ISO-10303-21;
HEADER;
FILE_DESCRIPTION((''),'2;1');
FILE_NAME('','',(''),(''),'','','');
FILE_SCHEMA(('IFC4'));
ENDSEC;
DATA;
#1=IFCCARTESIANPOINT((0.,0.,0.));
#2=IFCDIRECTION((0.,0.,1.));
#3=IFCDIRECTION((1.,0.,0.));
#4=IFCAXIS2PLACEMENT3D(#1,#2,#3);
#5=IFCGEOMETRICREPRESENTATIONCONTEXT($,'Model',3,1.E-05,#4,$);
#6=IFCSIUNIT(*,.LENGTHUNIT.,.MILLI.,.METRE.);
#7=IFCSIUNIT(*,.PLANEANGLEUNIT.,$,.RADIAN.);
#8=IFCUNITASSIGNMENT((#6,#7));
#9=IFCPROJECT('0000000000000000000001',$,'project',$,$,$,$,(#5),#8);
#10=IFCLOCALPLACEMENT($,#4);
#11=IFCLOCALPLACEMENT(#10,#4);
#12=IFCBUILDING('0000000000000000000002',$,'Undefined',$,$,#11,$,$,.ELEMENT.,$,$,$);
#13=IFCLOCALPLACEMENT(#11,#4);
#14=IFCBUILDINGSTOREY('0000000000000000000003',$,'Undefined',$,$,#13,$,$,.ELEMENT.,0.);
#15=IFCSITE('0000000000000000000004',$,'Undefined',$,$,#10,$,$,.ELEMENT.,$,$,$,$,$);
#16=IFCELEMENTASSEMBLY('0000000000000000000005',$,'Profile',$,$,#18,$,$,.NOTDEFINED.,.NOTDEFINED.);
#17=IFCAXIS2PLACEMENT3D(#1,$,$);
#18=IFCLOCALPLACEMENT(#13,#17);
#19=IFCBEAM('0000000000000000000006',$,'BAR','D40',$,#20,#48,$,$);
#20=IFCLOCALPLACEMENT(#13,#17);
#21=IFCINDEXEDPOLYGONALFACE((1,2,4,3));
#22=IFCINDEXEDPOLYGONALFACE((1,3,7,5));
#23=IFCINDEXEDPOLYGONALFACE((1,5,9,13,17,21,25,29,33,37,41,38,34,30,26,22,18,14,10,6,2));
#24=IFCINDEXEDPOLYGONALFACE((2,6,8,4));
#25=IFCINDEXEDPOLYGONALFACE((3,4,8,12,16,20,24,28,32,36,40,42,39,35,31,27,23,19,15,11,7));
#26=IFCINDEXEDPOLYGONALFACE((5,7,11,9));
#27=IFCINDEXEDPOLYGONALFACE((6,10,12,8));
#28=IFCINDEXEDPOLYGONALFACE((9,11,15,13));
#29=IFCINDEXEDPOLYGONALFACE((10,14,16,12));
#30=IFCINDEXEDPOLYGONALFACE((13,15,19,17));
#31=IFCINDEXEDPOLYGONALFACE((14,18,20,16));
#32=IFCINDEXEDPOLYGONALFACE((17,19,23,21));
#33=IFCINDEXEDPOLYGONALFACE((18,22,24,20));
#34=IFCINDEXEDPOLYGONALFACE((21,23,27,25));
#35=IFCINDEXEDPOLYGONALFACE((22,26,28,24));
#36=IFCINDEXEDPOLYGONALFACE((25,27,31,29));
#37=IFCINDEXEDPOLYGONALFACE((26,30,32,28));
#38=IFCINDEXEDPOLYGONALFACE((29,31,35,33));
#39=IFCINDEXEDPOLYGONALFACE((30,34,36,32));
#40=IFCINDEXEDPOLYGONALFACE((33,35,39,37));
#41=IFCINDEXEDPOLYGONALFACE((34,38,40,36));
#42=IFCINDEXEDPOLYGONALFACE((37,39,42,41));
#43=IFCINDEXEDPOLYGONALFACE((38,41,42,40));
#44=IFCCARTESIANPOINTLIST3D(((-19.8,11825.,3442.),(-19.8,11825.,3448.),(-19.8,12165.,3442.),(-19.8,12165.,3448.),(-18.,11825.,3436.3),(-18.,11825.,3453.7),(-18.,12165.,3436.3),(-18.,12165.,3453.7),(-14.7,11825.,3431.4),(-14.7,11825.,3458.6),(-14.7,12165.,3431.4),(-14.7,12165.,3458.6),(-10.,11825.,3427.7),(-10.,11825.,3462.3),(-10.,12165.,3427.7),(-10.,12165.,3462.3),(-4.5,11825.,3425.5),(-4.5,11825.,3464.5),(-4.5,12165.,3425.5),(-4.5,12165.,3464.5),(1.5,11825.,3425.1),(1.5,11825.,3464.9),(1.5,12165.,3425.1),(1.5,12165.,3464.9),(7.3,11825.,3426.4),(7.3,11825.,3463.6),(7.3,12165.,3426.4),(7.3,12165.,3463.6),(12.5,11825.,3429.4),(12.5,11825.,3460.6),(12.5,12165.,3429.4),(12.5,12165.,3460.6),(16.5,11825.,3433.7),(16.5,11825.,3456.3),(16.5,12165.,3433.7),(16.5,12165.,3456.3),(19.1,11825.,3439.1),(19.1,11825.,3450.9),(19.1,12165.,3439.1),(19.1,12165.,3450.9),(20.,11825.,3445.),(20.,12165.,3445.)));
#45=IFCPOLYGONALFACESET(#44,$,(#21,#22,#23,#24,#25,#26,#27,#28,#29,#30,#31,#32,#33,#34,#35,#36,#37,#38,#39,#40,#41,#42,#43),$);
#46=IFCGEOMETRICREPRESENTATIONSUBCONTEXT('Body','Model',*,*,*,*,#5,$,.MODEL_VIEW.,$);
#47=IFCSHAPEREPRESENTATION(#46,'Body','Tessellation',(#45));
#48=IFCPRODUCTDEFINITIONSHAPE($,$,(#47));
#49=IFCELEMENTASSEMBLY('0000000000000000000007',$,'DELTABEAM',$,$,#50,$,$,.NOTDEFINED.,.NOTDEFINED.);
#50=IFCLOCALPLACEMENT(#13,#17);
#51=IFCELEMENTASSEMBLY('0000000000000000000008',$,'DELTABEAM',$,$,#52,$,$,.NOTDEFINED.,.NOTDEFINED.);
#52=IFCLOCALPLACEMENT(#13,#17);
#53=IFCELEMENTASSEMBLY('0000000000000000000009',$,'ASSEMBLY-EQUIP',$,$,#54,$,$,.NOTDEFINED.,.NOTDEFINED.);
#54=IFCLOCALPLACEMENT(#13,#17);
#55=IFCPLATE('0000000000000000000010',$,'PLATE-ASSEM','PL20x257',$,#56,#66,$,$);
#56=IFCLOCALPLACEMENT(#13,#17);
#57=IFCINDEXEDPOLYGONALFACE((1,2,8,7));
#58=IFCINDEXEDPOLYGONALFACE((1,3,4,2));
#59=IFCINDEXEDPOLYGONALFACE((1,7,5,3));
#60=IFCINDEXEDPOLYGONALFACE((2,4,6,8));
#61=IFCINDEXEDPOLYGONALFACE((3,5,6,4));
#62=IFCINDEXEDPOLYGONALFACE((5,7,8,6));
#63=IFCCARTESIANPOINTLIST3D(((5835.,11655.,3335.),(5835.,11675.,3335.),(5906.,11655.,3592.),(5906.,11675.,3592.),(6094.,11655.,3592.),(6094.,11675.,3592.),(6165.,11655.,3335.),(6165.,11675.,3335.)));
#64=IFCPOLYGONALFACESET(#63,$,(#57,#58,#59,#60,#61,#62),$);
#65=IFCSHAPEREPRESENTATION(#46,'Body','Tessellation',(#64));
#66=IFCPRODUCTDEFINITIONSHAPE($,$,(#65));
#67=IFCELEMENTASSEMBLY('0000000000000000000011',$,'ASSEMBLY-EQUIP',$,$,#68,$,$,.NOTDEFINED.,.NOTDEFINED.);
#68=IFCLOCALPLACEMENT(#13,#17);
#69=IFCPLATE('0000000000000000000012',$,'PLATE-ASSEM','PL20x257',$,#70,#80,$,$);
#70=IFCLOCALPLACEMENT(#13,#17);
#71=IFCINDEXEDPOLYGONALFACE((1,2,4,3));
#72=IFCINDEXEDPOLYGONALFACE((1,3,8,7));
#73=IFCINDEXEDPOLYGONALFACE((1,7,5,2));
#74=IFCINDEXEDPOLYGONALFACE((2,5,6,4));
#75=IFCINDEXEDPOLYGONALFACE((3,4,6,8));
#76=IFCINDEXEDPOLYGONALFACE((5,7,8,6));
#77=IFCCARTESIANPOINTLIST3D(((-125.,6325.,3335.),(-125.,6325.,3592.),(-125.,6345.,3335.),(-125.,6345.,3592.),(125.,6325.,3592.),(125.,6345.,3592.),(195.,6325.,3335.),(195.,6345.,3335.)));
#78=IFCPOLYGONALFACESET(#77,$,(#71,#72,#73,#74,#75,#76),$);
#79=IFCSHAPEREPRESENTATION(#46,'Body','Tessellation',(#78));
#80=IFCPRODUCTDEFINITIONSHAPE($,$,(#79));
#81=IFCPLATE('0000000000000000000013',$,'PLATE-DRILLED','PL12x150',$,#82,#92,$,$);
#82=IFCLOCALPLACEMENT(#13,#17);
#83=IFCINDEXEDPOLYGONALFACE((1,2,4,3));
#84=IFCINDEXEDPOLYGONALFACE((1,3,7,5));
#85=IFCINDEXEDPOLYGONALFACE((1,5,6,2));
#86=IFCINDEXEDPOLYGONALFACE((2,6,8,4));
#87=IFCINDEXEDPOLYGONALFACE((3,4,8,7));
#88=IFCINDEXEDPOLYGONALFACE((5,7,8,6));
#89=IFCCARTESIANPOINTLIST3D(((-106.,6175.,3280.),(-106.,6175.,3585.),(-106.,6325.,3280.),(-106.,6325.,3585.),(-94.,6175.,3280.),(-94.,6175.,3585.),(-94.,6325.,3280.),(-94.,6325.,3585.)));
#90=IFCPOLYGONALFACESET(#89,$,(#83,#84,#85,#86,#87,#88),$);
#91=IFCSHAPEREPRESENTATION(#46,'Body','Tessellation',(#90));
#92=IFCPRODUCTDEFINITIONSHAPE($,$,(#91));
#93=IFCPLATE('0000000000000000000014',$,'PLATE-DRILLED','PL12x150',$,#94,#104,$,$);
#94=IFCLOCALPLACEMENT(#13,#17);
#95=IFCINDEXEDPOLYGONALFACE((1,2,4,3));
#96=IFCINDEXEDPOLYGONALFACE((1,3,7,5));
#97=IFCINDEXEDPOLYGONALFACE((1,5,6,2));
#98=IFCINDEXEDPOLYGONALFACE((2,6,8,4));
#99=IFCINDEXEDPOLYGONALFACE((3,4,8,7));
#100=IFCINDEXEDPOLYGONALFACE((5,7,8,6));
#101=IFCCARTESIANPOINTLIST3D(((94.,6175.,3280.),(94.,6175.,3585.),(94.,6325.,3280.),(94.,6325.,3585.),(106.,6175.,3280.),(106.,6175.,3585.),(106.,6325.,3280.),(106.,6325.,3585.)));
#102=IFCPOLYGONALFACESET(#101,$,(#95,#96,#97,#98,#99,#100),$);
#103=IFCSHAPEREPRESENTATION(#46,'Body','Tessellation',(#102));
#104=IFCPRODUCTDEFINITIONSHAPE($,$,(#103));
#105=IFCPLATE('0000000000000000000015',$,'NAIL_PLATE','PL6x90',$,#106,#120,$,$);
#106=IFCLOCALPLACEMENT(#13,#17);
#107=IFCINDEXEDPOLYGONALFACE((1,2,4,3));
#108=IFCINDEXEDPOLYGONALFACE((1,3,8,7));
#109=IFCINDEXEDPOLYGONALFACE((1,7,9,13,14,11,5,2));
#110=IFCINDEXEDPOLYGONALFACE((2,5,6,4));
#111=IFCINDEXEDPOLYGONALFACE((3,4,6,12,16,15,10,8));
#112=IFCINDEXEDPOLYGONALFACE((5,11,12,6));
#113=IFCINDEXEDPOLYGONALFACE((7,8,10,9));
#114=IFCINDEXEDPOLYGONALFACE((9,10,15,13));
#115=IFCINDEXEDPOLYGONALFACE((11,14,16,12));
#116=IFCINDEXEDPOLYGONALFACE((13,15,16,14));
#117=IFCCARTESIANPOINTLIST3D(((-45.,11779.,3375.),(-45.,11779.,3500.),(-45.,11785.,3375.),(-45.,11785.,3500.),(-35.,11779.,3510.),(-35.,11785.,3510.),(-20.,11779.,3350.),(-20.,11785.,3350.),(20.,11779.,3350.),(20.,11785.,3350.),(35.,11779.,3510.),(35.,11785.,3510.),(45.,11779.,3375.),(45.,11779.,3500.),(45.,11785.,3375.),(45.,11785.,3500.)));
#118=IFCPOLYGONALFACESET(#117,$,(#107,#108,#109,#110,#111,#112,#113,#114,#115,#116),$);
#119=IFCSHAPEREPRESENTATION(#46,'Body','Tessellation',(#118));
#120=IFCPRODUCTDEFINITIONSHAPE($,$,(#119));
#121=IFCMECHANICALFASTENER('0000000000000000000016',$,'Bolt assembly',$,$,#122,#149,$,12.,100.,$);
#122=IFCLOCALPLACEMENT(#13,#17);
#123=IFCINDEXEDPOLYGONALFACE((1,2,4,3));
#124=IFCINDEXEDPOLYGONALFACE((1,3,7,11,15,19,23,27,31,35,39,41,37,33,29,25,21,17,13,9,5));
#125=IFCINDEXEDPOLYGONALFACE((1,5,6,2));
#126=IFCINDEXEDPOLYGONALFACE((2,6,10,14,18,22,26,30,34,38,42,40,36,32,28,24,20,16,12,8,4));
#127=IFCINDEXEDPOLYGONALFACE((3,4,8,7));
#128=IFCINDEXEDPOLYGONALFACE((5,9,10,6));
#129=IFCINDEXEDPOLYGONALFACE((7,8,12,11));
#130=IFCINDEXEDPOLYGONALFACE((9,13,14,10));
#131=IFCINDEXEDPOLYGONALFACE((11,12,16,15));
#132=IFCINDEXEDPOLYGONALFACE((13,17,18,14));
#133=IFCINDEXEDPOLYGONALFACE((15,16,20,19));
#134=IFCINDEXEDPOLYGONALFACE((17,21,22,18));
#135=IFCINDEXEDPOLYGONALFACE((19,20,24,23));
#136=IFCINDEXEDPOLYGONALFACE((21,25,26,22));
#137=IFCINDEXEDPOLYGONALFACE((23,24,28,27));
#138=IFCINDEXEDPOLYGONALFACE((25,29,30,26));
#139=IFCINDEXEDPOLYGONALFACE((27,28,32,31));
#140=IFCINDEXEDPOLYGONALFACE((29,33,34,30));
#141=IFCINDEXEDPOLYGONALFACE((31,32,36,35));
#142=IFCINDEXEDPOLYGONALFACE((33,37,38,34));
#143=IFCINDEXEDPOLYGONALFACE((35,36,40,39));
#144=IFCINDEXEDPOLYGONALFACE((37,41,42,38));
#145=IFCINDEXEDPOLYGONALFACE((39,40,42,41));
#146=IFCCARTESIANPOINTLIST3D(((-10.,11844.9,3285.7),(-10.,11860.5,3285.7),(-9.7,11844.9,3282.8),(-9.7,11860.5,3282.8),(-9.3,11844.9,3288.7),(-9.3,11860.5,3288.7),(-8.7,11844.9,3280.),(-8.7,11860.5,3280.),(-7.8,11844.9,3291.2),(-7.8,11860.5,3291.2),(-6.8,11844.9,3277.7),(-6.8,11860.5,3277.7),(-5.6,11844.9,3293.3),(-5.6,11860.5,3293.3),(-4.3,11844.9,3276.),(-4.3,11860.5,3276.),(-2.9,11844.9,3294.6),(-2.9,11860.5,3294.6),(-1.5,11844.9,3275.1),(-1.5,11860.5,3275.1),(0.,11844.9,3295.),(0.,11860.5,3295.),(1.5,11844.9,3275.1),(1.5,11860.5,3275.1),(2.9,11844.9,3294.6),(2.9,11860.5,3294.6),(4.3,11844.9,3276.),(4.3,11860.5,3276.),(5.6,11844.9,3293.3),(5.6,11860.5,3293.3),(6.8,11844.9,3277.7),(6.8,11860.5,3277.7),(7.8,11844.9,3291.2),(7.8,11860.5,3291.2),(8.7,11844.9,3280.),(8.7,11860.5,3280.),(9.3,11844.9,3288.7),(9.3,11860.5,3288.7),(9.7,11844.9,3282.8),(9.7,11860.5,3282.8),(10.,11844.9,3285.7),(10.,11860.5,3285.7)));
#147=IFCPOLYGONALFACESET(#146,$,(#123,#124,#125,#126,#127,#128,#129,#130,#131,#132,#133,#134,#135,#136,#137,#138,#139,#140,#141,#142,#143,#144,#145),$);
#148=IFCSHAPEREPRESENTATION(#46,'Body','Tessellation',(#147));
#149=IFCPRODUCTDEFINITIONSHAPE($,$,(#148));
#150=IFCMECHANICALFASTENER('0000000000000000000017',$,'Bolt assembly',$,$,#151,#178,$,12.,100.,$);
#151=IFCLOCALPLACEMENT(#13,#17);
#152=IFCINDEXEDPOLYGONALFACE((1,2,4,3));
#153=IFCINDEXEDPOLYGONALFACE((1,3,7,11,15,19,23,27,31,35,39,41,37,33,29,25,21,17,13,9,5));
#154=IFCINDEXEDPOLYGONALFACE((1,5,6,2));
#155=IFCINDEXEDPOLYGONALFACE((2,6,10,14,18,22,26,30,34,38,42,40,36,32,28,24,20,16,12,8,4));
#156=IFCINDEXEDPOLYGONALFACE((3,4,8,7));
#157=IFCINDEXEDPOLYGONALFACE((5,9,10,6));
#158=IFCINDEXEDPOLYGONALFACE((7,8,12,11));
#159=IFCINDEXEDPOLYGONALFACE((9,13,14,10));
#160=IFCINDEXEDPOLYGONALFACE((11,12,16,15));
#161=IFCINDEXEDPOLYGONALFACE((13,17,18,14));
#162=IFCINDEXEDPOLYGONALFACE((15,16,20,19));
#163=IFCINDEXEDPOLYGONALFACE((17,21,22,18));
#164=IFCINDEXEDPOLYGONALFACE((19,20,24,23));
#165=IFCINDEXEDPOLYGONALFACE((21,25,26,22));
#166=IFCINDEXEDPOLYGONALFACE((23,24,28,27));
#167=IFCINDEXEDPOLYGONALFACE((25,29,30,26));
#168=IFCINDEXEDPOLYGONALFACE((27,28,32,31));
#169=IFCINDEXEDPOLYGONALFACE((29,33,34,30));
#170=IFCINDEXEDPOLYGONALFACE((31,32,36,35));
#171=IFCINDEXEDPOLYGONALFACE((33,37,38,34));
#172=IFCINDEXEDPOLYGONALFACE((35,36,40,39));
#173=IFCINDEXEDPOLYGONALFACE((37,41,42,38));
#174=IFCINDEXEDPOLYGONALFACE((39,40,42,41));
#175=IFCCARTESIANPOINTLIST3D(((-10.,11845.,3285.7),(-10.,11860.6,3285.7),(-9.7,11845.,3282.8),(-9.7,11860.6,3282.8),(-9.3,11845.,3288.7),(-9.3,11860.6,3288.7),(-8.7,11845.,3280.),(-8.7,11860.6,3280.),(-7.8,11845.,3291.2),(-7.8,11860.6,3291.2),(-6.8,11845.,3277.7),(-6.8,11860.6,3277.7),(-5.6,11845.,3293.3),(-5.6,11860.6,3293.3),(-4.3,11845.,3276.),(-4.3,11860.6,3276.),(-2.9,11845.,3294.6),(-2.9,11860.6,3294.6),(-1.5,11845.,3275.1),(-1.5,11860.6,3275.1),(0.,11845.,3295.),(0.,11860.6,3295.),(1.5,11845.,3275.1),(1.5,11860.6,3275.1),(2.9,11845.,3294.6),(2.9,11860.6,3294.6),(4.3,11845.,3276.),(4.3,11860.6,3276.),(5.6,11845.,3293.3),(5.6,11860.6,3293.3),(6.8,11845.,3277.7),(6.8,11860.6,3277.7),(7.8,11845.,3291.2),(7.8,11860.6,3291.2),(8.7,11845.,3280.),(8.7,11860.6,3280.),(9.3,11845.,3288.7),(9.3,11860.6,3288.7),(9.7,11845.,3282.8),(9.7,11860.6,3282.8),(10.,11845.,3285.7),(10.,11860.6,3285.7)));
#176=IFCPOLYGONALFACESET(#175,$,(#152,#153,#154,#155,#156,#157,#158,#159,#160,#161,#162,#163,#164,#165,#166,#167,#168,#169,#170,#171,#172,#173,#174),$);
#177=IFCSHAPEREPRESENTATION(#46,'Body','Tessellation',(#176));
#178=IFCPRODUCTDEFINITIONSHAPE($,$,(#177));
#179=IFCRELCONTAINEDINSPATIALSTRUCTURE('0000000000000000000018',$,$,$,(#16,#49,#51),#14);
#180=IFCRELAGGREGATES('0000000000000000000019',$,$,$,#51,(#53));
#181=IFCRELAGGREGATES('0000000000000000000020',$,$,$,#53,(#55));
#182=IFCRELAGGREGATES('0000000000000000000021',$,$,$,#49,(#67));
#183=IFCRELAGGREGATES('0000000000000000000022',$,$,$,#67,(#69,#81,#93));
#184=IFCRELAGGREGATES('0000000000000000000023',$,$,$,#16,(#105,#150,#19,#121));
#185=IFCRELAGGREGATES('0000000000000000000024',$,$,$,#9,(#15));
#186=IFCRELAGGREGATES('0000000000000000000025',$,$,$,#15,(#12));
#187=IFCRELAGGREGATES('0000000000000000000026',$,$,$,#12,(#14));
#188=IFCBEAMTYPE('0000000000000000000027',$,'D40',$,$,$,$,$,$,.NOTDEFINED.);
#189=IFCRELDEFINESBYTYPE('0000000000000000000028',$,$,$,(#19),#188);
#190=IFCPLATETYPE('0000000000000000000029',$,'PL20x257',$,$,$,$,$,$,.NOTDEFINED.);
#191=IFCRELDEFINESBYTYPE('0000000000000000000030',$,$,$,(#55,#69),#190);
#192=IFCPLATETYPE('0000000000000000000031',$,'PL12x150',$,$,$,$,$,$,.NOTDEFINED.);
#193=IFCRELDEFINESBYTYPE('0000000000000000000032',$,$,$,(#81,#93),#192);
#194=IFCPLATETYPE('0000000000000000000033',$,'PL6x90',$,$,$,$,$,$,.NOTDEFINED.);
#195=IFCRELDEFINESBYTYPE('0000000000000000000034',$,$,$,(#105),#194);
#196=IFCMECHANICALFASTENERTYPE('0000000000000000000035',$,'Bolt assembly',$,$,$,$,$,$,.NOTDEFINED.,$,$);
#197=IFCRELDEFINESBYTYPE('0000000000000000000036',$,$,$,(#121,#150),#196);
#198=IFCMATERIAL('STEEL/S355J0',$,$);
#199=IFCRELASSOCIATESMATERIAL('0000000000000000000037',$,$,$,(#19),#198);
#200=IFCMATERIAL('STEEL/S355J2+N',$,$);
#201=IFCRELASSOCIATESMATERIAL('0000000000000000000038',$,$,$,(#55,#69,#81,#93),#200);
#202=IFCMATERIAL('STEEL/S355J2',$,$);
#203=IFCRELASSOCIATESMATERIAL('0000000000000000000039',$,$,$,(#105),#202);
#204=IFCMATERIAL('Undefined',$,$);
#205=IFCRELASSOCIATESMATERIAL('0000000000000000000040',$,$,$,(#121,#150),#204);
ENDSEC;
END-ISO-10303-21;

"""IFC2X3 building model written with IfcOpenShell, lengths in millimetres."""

from ifc_helpers import new_model, si_unit, frame, origin_with_axes, origin_2d_with_axis, place, context, subcontext, project, spatial, polyline, circle, outline, extrude, source, transform, mapped, material, type_object, element, aggregate, save


model = new_model("IFC2X3")

# Units and contexts
model_context = context("Model", 3, precision=1e-05, world=origin_with_axes())
body_context = subcontext(model_context, "Body", "Model", "MODEL_VIEW")
ifc_project = project(units=[si_unit("LENGTHUNIT", "METRE", prefix="MILLI"), si_unit("PLANEANGLEUNIT", "RADIAN")], contexts=[model_context])

# Site, building, storey
site_placement = place(None, origin_with_axes())
site = spatial("IfcSite", under=ifc_project, at=site_placement, Name="Undefined", CompositionType="ELEMENT")
building_placement = place(site_placement, origin_with_axes())
building = spatial("IfcBuilding", under=site, at=building_placement, Name="Undefined", CompositionType="ELEMENT")
storey_placement = place(building_placement, origin_with_axes())
storey = spatial("IfcBuildingStorey", under=building, at=storey_placement, Name="Undefined", CompositionType="ELEMENT", Elevation=0.0)

# Element assembly, beam
assembly_1_placement = place(storey_placement, origin_with_axes())
assembly_1 = element("IfcElementAssembly", 1, at=assembly_1_placement, inside=storey, Name="Profile", AssemblyPlace="NOTDEFINED", PredefinedType="NOTDEFINED")
ifc_material_1 = material(Name="STEEL/S355J0")
beam_type_1 = type_object("IfcBeamType", Name="D40", PredefinedType="NOTDEFINED")
beam_1_placement = place(assembly_1_placement, frame((0.0, 11825.0, 3445.0), z_axis=(0.0, 0.0, 1.0), x_axis=(0.0, 1.0, 0.0)))
beam_1 = element("IfcBeam", 2, at=beam_1_placement, type_object=beam_type_1, material=ifc_material_1, Name="BAR", Description="D40", context=body_context, shape_type="SweptSolid", body=[
    extrude(circle(Radius=20.0, at=origin_2d_with_axis()), frame((340.0, 0.0, 0.0), z_axis=(-1.0, 0.0, 0.0), x_axis=(0.0, -1.0, 0.0)), (0.0, 0.0, 1.0), 340.0),
])

# Element assembly
assembly_2_placement = place(storey_placement, origin_with_axes())
assembly_2 = element("IfcElementAssembly", 3, at=assembly_2_placement, inside=storey, Name="DELTABEAM", AssemblyPlace="NOTDEFINED", PredefinedType="NOTDEFINED")

# Element assemblies, plate
assembly_3_placement = place(storey_placement, origin_with_axes())
assembly_3 = element("IfcElementAssembly", 4, at=assembly_3_placement, inside=storey, Name="DELTABEAM", AssemblyPlace="NOTDEFINED", PredefinedType="NOTDEFINED")
assembly_4_placement = place(assembly_3_placement, origin_with_axes())
assembly_4 = element("IfcElementAssembly", 5, at=assembly_4_placement, Name="ASSEMBLY-EQUIP", AssemblyPlace="NOTDEFINED", PredefinedType="NOTDEFINED")
aggregate(assembly_3, [assembly_4])
ifc_material_2 = material(Name="STEEL/S355J2+N")
plate_type_1 = type_object("IfcPlateType", Name="PL20x257", PredefinedType="NOTDEFINED")
plate_1_placement = place(assembly_4_placement, frame((5835.0, 11665.0, 3335.0), z_axis=(0.0, -1.0, 0.0), x_axis=(1.0, 0.0, 0.0)))
plate_1 = element("IfcPlate", 6, at=plate_1_placement, type_object=plate_type_1, material=ifc_material_2, Name="PLATE-ASSEM", Description="PL20x257", context=body_context, shape_type="SweptSolid", body=[
    extrude(outline(polyline([(0.0, 0.0), (330.0, 0.0), (259.0, 257.0), (71.0, 257.0), (0.0, 0.0)])), frame((0.0, 0.0, -10.0), z_axis=(0.0, 0.0, 1.0), x_axis=(1.0, 0.0, 0.0)), (0.0, 0.0, 1.0), 20.0),
])
aggregate(assembly_4, [plate_1])

# Element assembly, plate
assembly_5_placement = place(assembly_2_placement, origin_with_axes())
assembly_5 = element("IfcElementAssembly", 7, at=assembly_5_placement, Name="ASSEMBLY-EQUIP", AssemblyPlace="NOTDEFINED", PredefinedType="NOTDEFINED")
plate_2_placement = place(assembly_5_placement, frame((195.0, 6335.0, 3335.0), z_axis=(0.0, 1.0, 0.0), x_axis=(-1.0, 0.0, 0.0)))
plate_2 = element("IfcPlate", 8, at=plate_2_placement, type_object=plate_type_1, material=ifc_material_2, Name="PLATE-ASSEM", Description="PL20x257", context=body_context, shape_type="SweptSolid", body=[
    extrude(outline(polyline([(0.0, 0.0), (320.0, 0.0), (320.0, 257.0), (70.0, 257.0), (0.0, 0.0)])), frame((0.0, 0.0, -10.0), z_axis=(0.0, 0.0, 1.0), x_axis=(1.0, 0.0, 0.0)), (0.0, 0.0, 1.0), 20.0),
])

# Plates
ifc_material_3 = material(Name="STEEL/S355J2")
aggregate(assembly_2, [assembly_5])
plate_type_2 = type_object("IfcPlateType", Name="PL12x150", PredefinedType="NOTDEFINED")
plate_3_placement = place(assembly_5_placement, frame((-100.0, 6325.0, 3585.0), z_axis=(1.0, 0.0, 0.0), x_axis=(0.0, -1.0, 0.0)))
plate_3 = element("IfcPlate", 9, at=plate_3_placement, type_object=plate_type_2, material=ifc_material_2, Name="PLATE-DRILLED", Description="PL12x150", context=body_context, shape_type="SweptSolid", body=[
    extrude(outline(polyline([(0.0, 0.0), (150.0, 0.0), (150.0, 0.0), (150.0, 305.0), (150.0, 305.0), (0.0, 305.0), (0.0, 305.0), (0.0, 0.0)])), frame((0.0, 0.0, -6.0), z_axis=(0.0, 0.0, 1.0), x_axis=(1.0, 0.0, 0.0)), (0.0, 0.0, 1.0), 12.0),
])
plate_4_placement = place(assembly_5_placement, frame((100.0, 6325.0, 3585.0), z_axis=(1.0, 0.0, 0.0), x_axis=(0.0, -1.0, 0.0)))
plate_4 = element("IfcPlate", 10, at=plate_4_placement, type_object=plate_type_2, material=ifc_material_2, Name="PLATE-DRILLED", Description="PL12x150", context=body_context, shape_type="SweptSolid", body=[
    extrude(outline(polyline([(0.0, 0.0), (150.0, 0.0), (150.0, 0.0), (150.0, 305.0), (150.0, 305.0), (0.0, 305.0), (0.0, 305.0), (0.0, 0.0)])), frame((0.0, 0.0, -6.0), z_axis=(0.0, 0.0, 1.0), x_axis=(1.0, 0.0, 0.0)), (0.0, 0.0, 1.0), 12.0),
])
plate_type_3 = type_object("IfcPlateType", Name="PL6x90", PredefinedType="NOTDEFINED")
plate_5_placement = place(assembly_1_placement, frame((-45.0, 11782.0, 3510.0), z_axis=(0.0, 1.0, 0.0), x_axis=(1.0, 0.0, 0.0)))
plate_5 = element("IfcPlate", 11, at=plate_5_placement, type_object=plate_type_3, material=ifc_material_3, Name="NAIL_PLATE", Description="PL6x90", context=body_context, shape_type="SweptSolid", body=[
    extrude(outline(polyline([(0.0, 10.0), (10.0, 0.0), (80.0, 0.0), (90.0, 10.0), (90.0, 135.0), (65.0, 160.0), (25.0, 160.0), (0.0, 135.0), (0.0, 10.0)])), frame((0.0, 0.0, -3.0), z_axis=(0.0, 0.0, 1.0), x_axis=(1.0, 0.0, 0.0)), (0.0, 0.0, 1.0), 6.0),
])

# Mechanical fasteners
mechanical_fastener_type = type_object("IfcMechanicalFastenerType", Name="Bolt assembly")
aggregate(assembly_5, [plate_2, plate_3, plate_4])
ifc_material_4 = material(Name="Undefined")
shared_shape_1 = source(origin_with_axes(), body_context, "Body", "SweptSolid", [
    extrude(circle(Radius=10.0, at=origin_2d_with_axis()), frame((0.0, -15.5, 0.0), z_axis=(0.0, 1.0, 0.0), x_axis=(1.0, 0.0, 0.0)), (0.0, 0.0, 1.0), 15.6),
])
mechanical_fastener_1_placement = place(assembly_1_placement, frame((0.0, 11845.0, 3285.0), z_axis=(1.0, 0.0, 0.0), x_axis=(0.0, 0.0, 1.0)))
mechanical_fastener_1 = element("IfcMechanicalFastener", 12, at=mechanical_fastener_1_placement, type_object=mechanical_fastener_type, material=ifc_material_4, Name="Bolt assembly", NominalDiameter=12.0, NominalLength=100.0, context=body_context, shape_type="MappedRepresentation", body=[
    mapped(shared_shape_1, transform((0.0, 0.0, 0.0))),
])
shared_shape_2 = source(origin_with_axes(), body_context, "Body", "SweptSolid", [
    extrude(circle(Radius=10.0, at=origin_2d_with_axis()), frame((0.0, 0.0, 0.0), z_axis=(0.0, 1.0, 0.0), x_axis=(1.0, 0.0, 0.0)), (0.0, 0.0, 1.0), 15.6),
])
mechanical_fastener_2_placement = place(assembly_1_placement, frame((0.0, 11845.0, 3285.0), z_axis=(-1.0, 0.0, 0.0), x_axis=(0.0, 0.0, 1.0)))
mechanical_fastener_2 = element("IfcMechanicalFastener", 13, at=mechanical_fastener_2_placement, type_object=mechanical_fastener_type, material=ifc_material_4, Name="Bolt assembly", NominalDiameter=12.0, NominalLength=100.0, context=body_context, shape_type="MappedRepresentation", body=[
    mapped(shared_shape_2, transform((0.0, 0.0, 0.0))),
])
aggregate(assembly_1, [plate_5, mechanical_fastener_2, beam_1, mechanical_fastener_1])

save(model, "model.ifc")
